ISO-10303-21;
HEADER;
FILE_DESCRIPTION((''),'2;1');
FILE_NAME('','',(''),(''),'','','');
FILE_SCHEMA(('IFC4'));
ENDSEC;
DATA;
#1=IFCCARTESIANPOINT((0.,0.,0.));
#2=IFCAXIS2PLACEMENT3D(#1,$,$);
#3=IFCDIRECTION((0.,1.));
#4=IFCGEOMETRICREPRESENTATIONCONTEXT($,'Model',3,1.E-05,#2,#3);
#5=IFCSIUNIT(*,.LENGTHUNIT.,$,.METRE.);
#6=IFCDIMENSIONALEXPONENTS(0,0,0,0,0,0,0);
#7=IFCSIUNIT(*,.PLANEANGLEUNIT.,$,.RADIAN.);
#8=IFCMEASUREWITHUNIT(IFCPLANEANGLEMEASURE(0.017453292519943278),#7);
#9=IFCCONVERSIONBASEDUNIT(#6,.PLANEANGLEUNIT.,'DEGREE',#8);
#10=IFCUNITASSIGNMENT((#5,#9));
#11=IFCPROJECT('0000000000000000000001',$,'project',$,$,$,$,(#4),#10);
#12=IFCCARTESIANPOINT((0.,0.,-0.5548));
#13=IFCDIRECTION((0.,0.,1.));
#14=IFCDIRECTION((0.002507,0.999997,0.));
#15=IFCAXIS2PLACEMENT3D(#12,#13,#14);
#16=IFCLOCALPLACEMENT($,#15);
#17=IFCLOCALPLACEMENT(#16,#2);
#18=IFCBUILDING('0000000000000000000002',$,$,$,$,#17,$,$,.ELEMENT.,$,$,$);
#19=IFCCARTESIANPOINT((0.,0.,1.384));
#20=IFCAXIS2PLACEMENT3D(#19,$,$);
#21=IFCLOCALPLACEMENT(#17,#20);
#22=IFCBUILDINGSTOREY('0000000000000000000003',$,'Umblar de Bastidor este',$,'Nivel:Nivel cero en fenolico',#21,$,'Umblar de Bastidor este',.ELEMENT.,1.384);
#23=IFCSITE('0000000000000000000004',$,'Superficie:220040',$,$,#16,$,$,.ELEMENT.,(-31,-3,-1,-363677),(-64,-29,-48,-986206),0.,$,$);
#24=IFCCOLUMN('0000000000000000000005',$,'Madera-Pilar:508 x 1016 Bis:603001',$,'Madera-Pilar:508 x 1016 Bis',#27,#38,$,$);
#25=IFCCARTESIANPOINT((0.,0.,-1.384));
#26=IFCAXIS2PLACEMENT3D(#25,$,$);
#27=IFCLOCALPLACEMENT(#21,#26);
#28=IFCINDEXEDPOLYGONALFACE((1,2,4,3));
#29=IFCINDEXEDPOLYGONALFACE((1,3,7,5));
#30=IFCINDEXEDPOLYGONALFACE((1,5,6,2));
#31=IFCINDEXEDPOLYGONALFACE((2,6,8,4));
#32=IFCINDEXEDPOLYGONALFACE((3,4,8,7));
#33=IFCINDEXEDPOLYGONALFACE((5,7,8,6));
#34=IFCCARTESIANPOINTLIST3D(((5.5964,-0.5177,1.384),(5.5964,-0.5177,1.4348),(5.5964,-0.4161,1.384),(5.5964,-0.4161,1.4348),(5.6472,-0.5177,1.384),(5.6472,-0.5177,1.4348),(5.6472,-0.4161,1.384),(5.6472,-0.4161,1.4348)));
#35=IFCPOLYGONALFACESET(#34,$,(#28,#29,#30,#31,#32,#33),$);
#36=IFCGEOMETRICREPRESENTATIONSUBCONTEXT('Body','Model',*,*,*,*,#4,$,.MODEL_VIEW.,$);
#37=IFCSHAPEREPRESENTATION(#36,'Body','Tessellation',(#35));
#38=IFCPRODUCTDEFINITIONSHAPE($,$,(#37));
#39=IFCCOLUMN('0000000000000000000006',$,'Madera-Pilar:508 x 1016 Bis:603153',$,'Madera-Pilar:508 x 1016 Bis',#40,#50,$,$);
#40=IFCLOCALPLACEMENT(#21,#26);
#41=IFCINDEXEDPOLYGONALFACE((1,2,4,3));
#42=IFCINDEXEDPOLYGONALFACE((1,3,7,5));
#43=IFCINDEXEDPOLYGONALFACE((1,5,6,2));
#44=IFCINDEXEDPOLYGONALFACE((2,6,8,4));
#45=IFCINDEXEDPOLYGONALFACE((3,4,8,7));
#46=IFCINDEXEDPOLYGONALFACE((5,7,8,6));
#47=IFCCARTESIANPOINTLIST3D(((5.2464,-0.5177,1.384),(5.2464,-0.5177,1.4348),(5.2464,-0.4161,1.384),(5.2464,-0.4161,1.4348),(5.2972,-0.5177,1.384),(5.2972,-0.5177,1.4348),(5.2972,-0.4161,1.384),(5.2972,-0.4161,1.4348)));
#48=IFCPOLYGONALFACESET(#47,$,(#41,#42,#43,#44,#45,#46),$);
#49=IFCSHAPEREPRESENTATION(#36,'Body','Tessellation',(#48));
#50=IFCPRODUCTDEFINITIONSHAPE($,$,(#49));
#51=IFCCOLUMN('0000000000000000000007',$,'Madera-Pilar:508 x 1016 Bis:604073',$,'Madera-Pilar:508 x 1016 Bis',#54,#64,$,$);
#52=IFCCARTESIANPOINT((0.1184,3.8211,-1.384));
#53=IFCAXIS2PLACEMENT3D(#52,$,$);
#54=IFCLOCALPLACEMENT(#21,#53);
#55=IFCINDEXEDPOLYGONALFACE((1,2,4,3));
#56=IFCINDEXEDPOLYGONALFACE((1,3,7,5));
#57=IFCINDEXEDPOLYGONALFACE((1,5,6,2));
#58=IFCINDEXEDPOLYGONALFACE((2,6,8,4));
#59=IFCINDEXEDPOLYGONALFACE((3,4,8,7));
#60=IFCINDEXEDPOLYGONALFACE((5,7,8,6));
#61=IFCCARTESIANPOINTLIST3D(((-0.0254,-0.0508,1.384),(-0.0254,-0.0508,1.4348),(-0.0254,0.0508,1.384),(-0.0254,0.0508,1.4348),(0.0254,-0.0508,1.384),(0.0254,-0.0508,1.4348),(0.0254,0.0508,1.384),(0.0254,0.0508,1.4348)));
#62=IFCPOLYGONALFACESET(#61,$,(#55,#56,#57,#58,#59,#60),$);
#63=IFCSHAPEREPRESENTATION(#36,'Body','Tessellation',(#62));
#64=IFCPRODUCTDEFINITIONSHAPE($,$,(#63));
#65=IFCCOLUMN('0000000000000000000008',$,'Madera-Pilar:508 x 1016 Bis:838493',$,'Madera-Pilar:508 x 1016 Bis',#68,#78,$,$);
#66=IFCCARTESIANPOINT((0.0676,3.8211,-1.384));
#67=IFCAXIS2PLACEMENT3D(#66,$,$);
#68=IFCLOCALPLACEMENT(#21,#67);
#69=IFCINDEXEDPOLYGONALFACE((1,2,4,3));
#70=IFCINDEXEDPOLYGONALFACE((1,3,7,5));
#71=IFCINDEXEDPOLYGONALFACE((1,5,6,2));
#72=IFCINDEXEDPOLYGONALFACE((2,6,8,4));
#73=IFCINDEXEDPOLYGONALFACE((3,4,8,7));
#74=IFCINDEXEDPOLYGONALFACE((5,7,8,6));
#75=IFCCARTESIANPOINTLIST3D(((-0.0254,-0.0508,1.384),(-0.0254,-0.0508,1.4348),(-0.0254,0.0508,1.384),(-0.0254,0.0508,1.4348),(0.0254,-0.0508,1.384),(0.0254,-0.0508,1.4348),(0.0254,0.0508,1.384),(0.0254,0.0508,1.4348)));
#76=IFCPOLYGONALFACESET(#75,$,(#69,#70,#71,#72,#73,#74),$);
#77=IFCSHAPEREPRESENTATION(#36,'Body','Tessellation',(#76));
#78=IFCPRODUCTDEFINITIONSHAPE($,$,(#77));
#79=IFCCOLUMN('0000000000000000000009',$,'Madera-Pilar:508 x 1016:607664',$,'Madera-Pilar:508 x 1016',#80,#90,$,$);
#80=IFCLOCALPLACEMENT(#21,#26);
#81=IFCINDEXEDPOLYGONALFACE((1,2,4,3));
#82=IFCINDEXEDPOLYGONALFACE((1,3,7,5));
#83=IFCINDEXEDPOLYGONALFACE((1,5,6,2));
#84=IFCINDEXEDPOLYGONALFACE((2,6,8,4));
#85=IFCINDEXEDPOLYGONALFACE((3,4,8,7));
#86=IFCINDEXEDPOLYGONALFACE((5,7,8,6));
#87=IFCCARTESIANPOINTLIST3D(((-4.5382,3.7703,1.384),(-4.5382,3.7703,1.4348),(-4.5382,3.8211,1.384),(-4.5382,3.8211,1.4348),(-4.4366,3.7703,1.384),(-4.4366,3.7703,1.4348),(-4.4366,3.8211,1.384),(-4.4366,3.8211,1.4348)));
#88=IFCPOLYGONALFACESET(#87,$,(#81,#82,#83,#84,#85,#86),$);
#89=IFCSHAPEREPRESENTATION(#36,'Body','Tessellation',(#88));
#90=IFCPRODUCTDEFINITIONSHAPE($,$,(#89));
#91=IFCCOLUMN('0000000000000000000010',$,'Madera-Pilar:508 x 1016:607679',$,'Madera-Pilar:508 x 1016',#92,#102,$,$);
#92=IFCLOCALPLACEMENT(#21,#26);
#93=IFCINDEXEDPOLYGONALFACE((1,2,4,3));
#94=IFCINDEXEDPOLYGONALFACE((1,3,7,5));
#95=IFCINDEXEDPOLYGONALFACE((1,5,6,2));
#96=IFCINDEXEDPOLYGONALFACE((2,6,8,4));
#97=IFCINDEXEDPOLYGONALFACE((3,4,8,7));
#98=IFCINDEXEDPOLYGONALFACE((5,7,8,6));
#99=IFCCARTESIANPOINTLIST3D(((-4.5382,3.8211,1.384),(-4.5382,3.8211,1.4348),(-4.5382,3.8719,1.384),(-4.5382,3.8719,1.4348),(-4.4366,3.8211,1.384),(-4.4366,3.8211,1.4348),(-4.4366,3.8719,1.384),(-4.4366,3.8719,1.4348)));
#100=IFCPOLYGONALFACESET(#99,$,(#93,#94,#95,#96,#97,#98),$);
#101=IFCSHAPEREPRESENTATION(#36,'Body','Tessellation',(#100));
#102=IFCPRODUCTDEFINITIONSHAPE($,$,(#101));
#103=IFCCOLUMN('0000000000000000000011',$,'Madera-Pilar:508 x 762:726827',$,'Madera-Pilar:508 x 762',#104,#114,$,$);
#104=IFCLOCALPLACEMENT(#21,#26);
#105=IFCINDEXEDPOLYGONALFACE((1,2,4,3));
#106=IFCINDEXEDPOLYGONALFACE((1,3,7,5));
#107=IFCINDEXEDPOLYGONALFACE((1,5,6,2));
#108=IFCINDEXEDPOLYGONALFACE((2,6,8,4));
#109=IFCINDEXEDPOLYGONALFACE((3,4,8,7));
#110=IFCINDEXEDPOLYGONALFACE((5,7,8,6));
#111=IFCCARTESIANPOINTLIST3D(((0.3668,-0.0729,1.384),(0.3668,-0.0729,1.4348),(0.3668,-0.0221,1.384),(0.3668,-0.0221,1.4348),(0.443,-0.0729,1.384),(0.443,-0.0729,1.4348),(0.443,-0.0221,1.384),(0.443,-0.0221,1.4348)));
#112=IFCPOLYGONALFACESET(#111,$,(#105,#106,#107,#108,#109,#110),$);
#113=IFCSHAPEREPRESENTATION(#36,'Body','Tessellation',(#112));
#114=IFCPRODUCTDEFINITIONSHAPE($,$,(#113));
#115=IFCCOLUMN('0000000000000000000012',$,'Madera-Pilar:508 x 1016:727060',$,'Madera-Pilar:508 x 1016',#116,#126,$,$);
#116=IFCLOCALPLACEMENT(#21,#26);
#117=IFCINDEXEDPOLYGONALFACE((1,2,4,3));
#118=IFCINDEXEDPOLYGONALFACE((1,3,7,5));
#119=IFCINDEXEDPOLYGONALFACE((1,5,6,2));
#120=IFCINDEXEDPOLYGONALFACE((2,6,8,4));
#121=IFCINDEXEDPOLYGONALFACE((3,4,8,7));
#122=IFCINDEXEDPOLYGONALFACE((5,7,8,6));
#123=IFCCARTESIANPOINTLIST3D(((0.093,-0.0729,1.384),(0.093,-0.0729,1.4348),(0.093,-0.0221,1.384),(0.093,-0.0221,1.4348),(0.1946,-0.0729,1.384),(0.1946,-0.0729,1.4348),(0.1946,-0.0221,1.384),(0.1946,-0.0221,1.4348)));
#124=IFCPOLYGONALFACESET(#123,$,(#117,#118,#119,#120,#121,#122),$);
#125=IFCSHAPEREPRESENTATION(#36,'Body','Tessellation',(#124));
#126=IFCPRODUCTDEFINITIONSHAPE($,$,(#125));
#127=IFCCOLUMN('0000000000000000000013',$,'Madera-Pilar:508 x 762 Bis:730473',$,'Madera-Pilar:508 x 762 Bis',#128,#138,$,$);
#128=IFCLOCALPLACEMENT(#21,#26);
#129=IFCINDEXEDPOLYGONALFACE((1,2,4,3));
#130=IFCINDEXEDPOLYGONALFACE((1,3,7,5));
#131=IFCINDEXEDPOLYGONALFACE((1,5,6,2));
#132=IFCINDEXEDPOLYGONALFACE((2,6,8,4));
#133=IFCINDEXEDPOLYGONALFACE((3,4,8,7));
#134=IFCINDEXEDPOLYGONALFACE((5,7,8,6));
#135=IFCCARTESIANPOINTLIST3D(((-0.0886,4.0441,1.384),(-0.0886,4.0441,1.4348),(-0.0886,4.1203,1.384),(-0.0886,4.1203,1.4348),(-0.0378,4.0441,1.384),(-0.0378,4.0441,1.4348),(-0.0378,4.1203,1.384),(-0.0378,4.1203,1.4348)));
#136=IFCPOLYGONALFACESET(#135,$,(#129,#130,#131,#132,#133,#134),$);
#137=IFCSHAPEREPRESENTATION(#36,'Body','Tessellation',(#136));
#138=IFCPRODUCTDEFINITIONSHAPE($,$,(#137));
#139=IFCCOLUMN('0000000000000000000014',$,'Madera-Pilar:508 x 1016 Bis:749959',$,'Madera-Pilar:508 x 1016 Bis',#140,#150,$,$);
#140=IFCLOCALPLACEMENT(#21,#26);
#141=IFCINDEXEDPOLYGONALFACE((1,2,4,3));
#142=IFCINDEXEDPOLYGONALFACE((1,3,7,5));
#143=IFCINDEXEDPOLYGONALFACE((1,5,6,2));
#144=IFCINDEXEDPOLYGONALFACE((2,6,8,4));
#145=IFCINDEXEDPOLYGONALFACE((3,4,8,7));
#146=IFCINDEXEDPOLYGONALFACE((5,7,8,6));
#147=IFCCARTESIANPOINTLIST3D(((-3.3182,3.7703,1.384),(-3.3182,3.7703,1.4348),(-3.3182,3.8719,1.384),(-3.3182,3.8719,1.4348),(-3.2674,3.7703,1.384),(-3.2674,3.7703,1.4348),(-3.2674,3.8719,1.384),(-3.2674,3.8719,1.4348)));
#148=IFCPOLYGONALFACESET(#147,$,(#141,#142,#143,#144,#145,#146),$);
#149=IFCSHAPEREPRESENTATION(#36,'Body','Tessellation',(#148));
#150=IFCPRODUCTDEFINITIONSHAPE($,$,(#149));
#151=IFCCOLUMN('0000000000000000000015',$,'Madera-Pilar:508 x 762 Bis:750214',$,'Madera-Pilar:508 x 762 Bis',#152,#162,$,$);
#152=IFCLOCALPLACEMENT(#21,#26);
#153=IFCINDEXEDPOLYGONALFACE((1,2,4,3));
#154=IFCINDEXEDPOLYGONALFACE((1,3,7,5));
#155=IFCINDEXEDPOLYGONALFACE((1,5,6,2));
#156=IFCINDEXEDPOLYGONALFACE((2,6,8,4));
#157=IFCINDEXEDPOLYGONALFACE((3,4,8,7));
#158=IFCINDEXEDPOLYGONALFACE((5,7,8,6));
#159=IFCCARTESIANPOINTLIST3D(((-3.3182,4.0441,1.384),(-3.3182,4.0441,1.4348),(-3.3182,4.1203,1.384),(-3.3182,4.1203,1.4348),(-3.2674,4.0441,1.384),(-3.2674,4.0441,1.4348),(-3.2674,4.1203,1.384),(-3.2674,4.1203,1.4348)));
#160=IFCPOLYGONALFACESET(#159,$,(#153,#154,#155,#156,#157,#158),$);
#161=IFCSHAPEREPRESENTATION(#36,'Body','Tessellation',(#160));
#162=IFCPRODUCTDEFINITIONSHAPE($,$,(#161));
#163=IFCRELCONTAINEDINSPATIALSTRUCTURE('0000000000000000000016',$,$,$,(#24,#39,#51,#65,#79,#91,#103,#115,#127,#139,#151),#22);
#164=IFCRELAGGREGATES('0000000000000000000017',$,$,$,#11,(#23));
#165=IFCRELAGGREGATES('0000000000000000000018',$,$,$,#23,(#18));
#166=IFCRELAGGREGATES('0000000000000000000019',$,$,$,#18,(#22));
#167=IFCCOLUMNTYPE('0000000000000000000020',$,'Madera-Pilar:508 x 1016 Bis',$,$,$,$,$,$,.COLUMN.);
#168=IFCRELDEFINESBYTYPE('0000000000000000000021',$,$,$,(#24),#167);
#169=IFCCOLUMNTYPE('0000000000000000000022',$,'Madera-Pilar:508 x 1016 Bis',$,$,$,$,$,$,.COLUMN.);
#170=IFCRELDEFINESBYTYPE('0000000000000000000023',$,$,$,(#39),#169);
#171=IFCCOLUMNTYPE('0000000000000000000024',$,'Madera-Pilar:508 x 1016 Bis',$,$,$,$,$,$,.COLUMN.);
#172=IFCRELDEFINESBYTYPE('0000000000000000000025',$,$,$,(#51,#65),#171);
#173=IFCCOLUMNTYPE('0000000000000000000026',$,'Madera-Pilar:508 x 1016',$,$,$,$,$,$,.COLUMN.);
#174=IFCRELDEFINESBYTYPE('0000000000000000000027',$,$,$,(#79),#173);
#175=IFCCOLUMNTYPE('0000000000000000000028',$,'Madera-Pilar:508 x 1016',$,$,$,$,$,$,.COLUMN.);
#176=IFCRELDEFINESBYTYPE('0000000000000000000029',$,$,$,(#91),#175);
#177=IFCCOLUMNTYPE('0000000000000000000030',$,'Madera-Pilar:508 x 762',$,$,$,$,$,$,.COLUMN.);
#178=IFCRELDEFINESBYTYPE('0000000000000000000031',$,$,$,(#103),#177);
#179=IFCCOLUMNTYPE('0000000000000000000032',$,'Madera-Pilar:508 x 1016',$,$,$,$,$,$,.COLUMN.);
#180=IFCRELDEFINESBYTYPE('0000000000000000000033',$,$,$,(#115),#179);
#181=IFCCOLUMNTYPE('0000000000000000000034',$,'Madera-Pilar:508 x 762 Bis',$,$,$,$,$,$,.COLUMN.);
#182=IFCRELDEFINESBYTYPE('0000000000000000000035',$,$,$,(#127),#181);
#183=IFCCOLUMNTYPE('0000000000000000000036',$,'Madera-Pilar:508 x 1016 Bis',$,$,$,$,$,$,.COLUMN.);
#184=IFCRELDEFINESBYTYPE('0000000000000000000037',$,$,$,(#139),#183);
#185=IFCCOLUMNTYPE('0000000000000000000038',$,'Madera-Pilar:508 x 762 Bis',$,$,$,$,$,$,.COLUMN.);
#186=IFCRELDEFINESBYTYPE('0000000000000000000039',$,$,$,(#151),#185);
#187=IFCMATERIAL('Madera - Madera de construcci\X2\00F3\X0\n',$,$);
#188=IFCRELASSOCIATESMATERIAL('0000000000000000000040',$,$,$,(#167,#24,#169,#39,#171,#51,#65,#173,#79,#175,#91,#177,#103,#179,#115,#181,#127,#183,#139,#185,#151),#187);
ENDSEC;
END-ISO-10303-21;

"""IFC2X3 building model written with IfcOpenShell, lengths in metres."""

from ifc_helpers import new_model, entity, si_unit, converted_unit, direction, frame, frame_2d, origin, origin_2d_with_axis, place, context, subcontext, project, spatial, rectangle, extrude, source, transform, mapped, material, type_object, type_shapes, element, save


model = new_model("IFC2X3")

# Units and contexts
model_context = context("Model", 3, precision=1e-05, world=origin(), true_north=direction((0.0, 1.0)))
body_context = subcontext(model_context, "Body", "Model", "MODEL_VIEW")
ifc_project = project(units=[si_unit("LENGTHUNIT", "METRE"), converted_unit("PLANEANGLEUNIT", "DEGREE", entity("IfcPlaneAngleMeasure", 0.017453292519943278), si_unit("PLANEANGLEUNIT", "RADIAN"), dimensions=[0, 0, 0, 0, 0, 0, 0])], contexts=[model_context])

# Site, building, storey
site_placement = place(None, frame((0.0, 0.0, -0.5548), z_axis=(0.0, 0.0, 1.0), x_axis=(0.002507, 0.999997, 0.0)))
site = spatial("IfcSite", under=ifc_project, at=site_placement, Name="Superficie:220040", CompositionType="ELEMENT", RefLatitude=(-31, -3, -1, -363677), RefLongitude=(-64, -29, -48, -986206), RefElevation=0.0)
building_placement = place(site_placement, origin())
building = spatial("IfcBuilding", under=site, at=building_placement, CompositionType="ELEMENT")
storey_placement = place(building_placement, frame((0.0, 0.0, 1.384)))
storey = spatial("IfcBuildingStorey", under=building, at=storey_placement, Name="Umblar de Bastidor este", ObjectType="Nivel:Nivel cero en fenolico", LongName="Umblar de Bastidor este", CompositionType="ELEMENT", Elevation=1.384)

# Columns
ifc_material_1 = material(Name="Madera - Madera de construcción")
column_type_1 = type_object("IfcColumnType", Name="Madera-Pilar:508 x 1016 Bis", PredefinedType="COLUMN", material=ifc_material_1)
shared_shape_1 = source(origin(), body_context, "Body", "SweptSolid", [
    extrude(rectangle(XDim=0.0508, YDim=0.1016, at=frame_2d((0.0, 0.0), x_axis=(1.0, 0.0))), frame((5.6218, -0.4669, 1.384)), (0.0, 0.0, 1.0), 0.0508),
])
type_shapes(column_type_1, [shared_shape_1])
column_1_placement = place(storey_placement, frame((0.0, 0.0, -1.384)))
element("IfcColumn", 1, at=column_1_placement, inside=storey, type_object=column_type_1, material=ifc_material_1, Name="Madera-Pilar:508 x 1016 Bis:603001", ObjectType="Madera-Pilar:508 x 1016 Bis", context=body_context, shape_type="MappedRepresentation", body=[
    mapped(shared_shape_1, transform((0.0, 0.0, 0.0), scale=1.0)),
])
column_type_2 = type_object("IfcColumnType", Name="Madera-Pilar:508 x 1016 Bis", PredefinedType="COLUMN", material=ifc_material_1)
shared_shape_2 = source(origin(), body_context, "Body", "SweptSolid", [
    extrude(rectangle(XDim=0.0508, YDim=0.1016, at=frame_2d((0.0, 0.0), x_axis=(1.0, 0.0))), frame((5.2718, -0.4669, 1.384)), (0.0, 0.0, 1.0), 0.0508),
])
type_shapes(column_type_2, [shared_shape_2])
column_2_placement = place(storey_placement, frame((0.0, 0.0, -1.384)))
element("IfcColumn", 2, at=column_2_placement, inside=storey, type_object=column_type_2, material=ifc_material_1, Name="Madera-Pilar:508 x 1016 Bis:603153", ObjectType="Madera-Pilar:508 x 1016 Bis", context=body_context, shape_type="MappedRepresentation", body=[
    mapped(shared_shape_2, transform((0.0, 0.0, 0.0), scale=1.0)),
])
column_type_3 = type_object("IfcColumnType", Name="Madera-Pilar:508 x 1016 Bis", PredefinedType="COLUMN", material=ifc_material_1)
shared_shape_3 = source(origin(), body_context, "Body", "SweptSolid", [
    extrude(rectangle(XDim=0.0508, YDim=0.1016, at=origin_2d_with_axis()), frame((0.0, 0.0, 1.384), z_axis=(0.0, 0.0, 1.0), x_axis=(-1.0, 0.0, 0.0)), (0.0, 0.0, 1.0), 0.0508),
])
type_shapes(column_type_3, [shared_shape_3])
for number, where, name in (
    (3, (0.1184, 3.8211, -1.384), "Madera-Pilar:508 x 1016 Bis:604073"),
    (4, (0.0676, 3.8211, -1.384), "Madera-Pilar:508 x 1016 Bis:838493"),
):
    element("IfcColumn", number, at=place(storey_placement, frame(where)), inside=storey, type_object=column_type_3, material=ifc_material_1, Name=name, ObjectType="Madera-Pilar:508 x 1016 Bis", context=body_context, shape_type="MappedRepresentation", body=[
        mapped(shared_shape_3, transform((0.0, 0.0, 0.0), scale=1.0)),
    ])
column_type_4 = type_object("IfcColumnType", Name="Madera-Pilar:508 x 1016", PredefinedType="COLUMN", material=ifc_material_1)
shared_shape_4 = source(origin(), body_context, "Body", "SweptSolid", [
    extrude(rectangle(XDim=0.1016, YDim=0.0508, at=frame_2d((0.0, 0.0), x_axis=(1.0, 0.0))), frame((-4.4874, 3.7957, 1.384), z_axis=(0.0, 0.0, 1.0), x_axis=(-1.0, 0.0, 0.0)), (0.0, 0.0, 1.0), 0.0508),
])
type_shapes(column_type_4, [shared_shape_4])
column_3_placement = place(storey_placement, frame((0.0, 0.0, -1.384)))
element("IfcColumn", 5, at=column_3_placement, inside=storey, type_object=column_type_4, material=ifc_material_1, Name="Madera-Pilar:508 x 1016:607664", ObjectType="Madera-Pilar:508 x 1016", context=body_context, shape_type="MappedRepresentation", body=[
    mapped(shared_shape_4, transform((0.0, 0.0, 0.0), scale=1.0)),
])
column_type_5 = type_object("IfcColumnType", Name="Madera-Pilar:508 x 1016", PredefinedType="COLUMN", material=ifc_material_1)
shared_shape_5 = source(origin(), body_context, "Body", "SweptSolid", [
    extrude(rectangle(XDim=0.1016, YDim=0.0508, at=frame_2d((0.0, 0.0), x_axis=(1.0, 0.0))), frame((-4.4874, 3.8465, 1.384), z_axis=(0.0, 0.0, 1.0), x_axis=(-1.0, 0.0, 0.0)), (0.0, 0.0, 1.0), 0.0508),
])
type_shapes(column_type_5, [shared_shape_5])
column_4_placement = place(storey_placement, frame((0.0, 0.0, -1.384)))
element("IfcColumn", 6, at=column_4_placement, inside=storey, type_object=column_type_5, material=ifc_material_1, Name="Madera-Pilar:508 x 1016:607679", ObjectType="Madera-Pilar:508 x 1016", context=body_context, shape_type="MappedRepresentation", body=[
    mapped(shared_shape_5, transform((0.0, 0.0, 0.0), scale=1.0)),
])
column_type_6 = type_object("IfcColumnType", Name="Madera-Pilar:508 x 762", PredefinedType="COLUMN", material=ifc_material_1)
shared_shape_6 = source(origin(), body_context, "Body", "SweptSolid", [
    extrude(rectangle(XDim=0.0762, YDim=0.0508, at=origin_2d_with_axis()), frame((0.4049, -0.0475, 1.384), z_axis=(0.0, 0.0, 1.0), x_axis=(-1.0, 0.0, 0.0)), (0.0, 0.0, 1.0), 0.0508),
])
type_shapes(column_type_6, [shared_shape_6])
column_5_placement = place(storey_placement, frame((0.0, 0.0, -1.384)))
element("IfcColumn", 7, at=column_5_placement, inside=storey, type_object=column_type_6, material=ifc_material_1, Name="Madera-Pilar:508 x 762:726827", ObjectType="Madera-Pilar:508 x 762", context=body_context, shape_type="MappedRepresentation", body=[
    mapped(shared_shape_6, transform((0.0, 0.0, 0.0), scale=1.0)),
])
column_type_7 = type_object("IfcColumnType", Name="Madera-Pilar:508 x 1016", PredefinedType="COLUMN", material=ifc_material_1)
shared_shape_7 = source(origin(), body_context, "Body", "SweptSolid", [
    extrude(rectangle(XDim=0.1016, YDim=0.0508, at=frame_2d((0.0, 0.0), x_axis=(1.0, 0.0))), frame((0.1438, -0.0475, 1.384), z_axis=(0.0, 0.0, 1.0), x_axis=(-1.0, 0.0, 0.0)), (0.0, 0.0, 1.0), 0.0508),
])
type_shapes(column_type_7, [shared_shape_7])
column_6_placement = place(storey_placement, frame((0.0, 0.0, -1.384)))
element("IfcColumn", 8, at=column_6_placement, inside=storey, type_object=column_type_7, material=ifc_material_1, Name="Madera-Pilar:508 x 1016:727060", ObjectType="Madera-Pilar:508 x 1016", context=body_context, shape_type="MappedRepresentation", body=[
    mapped(shared_shape_7, transform((0.0, 0.0, 0.0), scale=1.0)),
])
column_type_8 = type_object("IfcColumnType", Name="Madera-Pilar:508 x 762 Bis", PredefinedType="COLUMN", material=ifc_material_1)
shared_shape_8 = source(origin(), body_context, "Body", "SweptSolid", [
    extrude(rectangle(XDim=0.0508, YDim=0.0762, at=frame_2d((0.0, 0.0), x_axis=(1.0, 0.0))), frame((-0.0632, 4.0822, 1.384), z_axis=(0.0, 0.0, 1.0), x_axis=(-1.0, 0.0, 0.0)), (0.0, 0.0, 1.0), 0.0508),
])
type_shapes(column_type_8, [shared_shape_8])
column_7_placement = place(storey_placement, frame((0.0, 0.0, -1.384)))
element("IfcColumn", 9, at=column_7_placement, inside=storey, type_object=column_type_8, material=ifc_material_1, Name="Madera-Pilar:508 x 762 Bis:730473", ObjectType="Madera-Pilar:508 x 762 Bis", context=body_context, shape_type="MappedRepresentation", body=[
    mapped(shared_shape_8, transform((0.0, 0.0, 0.0), scale=1.0)),
])
column_type_9 = type_object("IfcColumnType", Name="Madera-Pilar:508 x 1016 Bis", PredefinedType="COLUMN", material=ifc_material_1)
shared_shape_9 = source(origin(), body_context, "Body", "SweptSolid", [
    extrude(rectangle(XDim=0.0508, YDim=0.1016, at=frame_2d((0.0, 0.0), x_axis=(1.0, 0.0))), frame((-3.2928, 3.8211, 1.384), z_axis=(0.0, 0.0, 1.0), x_axis=(-1.0, 0.0, 0.0)), (0.0, 0.0, 1.0), 0.0508),
])
type_shapes(column_type_9, [shared_shape_9])
column_8_placement = place(storey_placement, frame((0.0, 0.0, -1.384)))
element("IfcColumn", 10, at=column_8_placement, inside=storey, type_object=column_type_9, material=ifc_material_1, Name="Madera-Pilar:508 x 1016 Bis:749959", ObjectType="Madera-Pilar:508 x 1016 Bis", context=body_context, shape_type="MappedRepresentation", body=[
    mapped(shared_shape_9, transform((0.0, 0.0, 0.0), scale=1.0)),
])
column_type_10 = type_object("IfcColumnType", Name="Madera-Pilar:508 x 762 Bis", PredefinedType="COLUMN", material=ifc_material_1)
shared_shape_10 = source(origin(), body_context, "Body", "SweptSolid", [
    extrude(rectangle(XDim=0.0508, YDim=0.0762, at=frame_2d((0.0, 0.0), x_axis=(1.0, 0.0))), frame((-3.2928, 4.0822, 1.384), z_axis=(0.0, 0.0, 1.0), x_axis=(-1.0, 0.0, 0.0)), (0.0, 0.0, 1.0), 0.0508),
])
type_shapes(column_type_10, [shared_shape_10])
column_9_placement = place(storey_placement, frame((0.0, 0.0, -1.384)))
element("IfcColumn", 11, at=column_9_placement, inside=storey, type_object=column_type_10, material=ifc_material_1, Name="Madera-Pilar:508 x 762 Bis:750214", ObjectType="Madera-Pilar:508 x 762 Bis", context=body_context, shape_type="MappedRepresentation", body=[
    mapped(shared_shape_10, transform((0.0, 0.0, 0.0), scale=1.0)),
])

save(model, "model.ifc")
